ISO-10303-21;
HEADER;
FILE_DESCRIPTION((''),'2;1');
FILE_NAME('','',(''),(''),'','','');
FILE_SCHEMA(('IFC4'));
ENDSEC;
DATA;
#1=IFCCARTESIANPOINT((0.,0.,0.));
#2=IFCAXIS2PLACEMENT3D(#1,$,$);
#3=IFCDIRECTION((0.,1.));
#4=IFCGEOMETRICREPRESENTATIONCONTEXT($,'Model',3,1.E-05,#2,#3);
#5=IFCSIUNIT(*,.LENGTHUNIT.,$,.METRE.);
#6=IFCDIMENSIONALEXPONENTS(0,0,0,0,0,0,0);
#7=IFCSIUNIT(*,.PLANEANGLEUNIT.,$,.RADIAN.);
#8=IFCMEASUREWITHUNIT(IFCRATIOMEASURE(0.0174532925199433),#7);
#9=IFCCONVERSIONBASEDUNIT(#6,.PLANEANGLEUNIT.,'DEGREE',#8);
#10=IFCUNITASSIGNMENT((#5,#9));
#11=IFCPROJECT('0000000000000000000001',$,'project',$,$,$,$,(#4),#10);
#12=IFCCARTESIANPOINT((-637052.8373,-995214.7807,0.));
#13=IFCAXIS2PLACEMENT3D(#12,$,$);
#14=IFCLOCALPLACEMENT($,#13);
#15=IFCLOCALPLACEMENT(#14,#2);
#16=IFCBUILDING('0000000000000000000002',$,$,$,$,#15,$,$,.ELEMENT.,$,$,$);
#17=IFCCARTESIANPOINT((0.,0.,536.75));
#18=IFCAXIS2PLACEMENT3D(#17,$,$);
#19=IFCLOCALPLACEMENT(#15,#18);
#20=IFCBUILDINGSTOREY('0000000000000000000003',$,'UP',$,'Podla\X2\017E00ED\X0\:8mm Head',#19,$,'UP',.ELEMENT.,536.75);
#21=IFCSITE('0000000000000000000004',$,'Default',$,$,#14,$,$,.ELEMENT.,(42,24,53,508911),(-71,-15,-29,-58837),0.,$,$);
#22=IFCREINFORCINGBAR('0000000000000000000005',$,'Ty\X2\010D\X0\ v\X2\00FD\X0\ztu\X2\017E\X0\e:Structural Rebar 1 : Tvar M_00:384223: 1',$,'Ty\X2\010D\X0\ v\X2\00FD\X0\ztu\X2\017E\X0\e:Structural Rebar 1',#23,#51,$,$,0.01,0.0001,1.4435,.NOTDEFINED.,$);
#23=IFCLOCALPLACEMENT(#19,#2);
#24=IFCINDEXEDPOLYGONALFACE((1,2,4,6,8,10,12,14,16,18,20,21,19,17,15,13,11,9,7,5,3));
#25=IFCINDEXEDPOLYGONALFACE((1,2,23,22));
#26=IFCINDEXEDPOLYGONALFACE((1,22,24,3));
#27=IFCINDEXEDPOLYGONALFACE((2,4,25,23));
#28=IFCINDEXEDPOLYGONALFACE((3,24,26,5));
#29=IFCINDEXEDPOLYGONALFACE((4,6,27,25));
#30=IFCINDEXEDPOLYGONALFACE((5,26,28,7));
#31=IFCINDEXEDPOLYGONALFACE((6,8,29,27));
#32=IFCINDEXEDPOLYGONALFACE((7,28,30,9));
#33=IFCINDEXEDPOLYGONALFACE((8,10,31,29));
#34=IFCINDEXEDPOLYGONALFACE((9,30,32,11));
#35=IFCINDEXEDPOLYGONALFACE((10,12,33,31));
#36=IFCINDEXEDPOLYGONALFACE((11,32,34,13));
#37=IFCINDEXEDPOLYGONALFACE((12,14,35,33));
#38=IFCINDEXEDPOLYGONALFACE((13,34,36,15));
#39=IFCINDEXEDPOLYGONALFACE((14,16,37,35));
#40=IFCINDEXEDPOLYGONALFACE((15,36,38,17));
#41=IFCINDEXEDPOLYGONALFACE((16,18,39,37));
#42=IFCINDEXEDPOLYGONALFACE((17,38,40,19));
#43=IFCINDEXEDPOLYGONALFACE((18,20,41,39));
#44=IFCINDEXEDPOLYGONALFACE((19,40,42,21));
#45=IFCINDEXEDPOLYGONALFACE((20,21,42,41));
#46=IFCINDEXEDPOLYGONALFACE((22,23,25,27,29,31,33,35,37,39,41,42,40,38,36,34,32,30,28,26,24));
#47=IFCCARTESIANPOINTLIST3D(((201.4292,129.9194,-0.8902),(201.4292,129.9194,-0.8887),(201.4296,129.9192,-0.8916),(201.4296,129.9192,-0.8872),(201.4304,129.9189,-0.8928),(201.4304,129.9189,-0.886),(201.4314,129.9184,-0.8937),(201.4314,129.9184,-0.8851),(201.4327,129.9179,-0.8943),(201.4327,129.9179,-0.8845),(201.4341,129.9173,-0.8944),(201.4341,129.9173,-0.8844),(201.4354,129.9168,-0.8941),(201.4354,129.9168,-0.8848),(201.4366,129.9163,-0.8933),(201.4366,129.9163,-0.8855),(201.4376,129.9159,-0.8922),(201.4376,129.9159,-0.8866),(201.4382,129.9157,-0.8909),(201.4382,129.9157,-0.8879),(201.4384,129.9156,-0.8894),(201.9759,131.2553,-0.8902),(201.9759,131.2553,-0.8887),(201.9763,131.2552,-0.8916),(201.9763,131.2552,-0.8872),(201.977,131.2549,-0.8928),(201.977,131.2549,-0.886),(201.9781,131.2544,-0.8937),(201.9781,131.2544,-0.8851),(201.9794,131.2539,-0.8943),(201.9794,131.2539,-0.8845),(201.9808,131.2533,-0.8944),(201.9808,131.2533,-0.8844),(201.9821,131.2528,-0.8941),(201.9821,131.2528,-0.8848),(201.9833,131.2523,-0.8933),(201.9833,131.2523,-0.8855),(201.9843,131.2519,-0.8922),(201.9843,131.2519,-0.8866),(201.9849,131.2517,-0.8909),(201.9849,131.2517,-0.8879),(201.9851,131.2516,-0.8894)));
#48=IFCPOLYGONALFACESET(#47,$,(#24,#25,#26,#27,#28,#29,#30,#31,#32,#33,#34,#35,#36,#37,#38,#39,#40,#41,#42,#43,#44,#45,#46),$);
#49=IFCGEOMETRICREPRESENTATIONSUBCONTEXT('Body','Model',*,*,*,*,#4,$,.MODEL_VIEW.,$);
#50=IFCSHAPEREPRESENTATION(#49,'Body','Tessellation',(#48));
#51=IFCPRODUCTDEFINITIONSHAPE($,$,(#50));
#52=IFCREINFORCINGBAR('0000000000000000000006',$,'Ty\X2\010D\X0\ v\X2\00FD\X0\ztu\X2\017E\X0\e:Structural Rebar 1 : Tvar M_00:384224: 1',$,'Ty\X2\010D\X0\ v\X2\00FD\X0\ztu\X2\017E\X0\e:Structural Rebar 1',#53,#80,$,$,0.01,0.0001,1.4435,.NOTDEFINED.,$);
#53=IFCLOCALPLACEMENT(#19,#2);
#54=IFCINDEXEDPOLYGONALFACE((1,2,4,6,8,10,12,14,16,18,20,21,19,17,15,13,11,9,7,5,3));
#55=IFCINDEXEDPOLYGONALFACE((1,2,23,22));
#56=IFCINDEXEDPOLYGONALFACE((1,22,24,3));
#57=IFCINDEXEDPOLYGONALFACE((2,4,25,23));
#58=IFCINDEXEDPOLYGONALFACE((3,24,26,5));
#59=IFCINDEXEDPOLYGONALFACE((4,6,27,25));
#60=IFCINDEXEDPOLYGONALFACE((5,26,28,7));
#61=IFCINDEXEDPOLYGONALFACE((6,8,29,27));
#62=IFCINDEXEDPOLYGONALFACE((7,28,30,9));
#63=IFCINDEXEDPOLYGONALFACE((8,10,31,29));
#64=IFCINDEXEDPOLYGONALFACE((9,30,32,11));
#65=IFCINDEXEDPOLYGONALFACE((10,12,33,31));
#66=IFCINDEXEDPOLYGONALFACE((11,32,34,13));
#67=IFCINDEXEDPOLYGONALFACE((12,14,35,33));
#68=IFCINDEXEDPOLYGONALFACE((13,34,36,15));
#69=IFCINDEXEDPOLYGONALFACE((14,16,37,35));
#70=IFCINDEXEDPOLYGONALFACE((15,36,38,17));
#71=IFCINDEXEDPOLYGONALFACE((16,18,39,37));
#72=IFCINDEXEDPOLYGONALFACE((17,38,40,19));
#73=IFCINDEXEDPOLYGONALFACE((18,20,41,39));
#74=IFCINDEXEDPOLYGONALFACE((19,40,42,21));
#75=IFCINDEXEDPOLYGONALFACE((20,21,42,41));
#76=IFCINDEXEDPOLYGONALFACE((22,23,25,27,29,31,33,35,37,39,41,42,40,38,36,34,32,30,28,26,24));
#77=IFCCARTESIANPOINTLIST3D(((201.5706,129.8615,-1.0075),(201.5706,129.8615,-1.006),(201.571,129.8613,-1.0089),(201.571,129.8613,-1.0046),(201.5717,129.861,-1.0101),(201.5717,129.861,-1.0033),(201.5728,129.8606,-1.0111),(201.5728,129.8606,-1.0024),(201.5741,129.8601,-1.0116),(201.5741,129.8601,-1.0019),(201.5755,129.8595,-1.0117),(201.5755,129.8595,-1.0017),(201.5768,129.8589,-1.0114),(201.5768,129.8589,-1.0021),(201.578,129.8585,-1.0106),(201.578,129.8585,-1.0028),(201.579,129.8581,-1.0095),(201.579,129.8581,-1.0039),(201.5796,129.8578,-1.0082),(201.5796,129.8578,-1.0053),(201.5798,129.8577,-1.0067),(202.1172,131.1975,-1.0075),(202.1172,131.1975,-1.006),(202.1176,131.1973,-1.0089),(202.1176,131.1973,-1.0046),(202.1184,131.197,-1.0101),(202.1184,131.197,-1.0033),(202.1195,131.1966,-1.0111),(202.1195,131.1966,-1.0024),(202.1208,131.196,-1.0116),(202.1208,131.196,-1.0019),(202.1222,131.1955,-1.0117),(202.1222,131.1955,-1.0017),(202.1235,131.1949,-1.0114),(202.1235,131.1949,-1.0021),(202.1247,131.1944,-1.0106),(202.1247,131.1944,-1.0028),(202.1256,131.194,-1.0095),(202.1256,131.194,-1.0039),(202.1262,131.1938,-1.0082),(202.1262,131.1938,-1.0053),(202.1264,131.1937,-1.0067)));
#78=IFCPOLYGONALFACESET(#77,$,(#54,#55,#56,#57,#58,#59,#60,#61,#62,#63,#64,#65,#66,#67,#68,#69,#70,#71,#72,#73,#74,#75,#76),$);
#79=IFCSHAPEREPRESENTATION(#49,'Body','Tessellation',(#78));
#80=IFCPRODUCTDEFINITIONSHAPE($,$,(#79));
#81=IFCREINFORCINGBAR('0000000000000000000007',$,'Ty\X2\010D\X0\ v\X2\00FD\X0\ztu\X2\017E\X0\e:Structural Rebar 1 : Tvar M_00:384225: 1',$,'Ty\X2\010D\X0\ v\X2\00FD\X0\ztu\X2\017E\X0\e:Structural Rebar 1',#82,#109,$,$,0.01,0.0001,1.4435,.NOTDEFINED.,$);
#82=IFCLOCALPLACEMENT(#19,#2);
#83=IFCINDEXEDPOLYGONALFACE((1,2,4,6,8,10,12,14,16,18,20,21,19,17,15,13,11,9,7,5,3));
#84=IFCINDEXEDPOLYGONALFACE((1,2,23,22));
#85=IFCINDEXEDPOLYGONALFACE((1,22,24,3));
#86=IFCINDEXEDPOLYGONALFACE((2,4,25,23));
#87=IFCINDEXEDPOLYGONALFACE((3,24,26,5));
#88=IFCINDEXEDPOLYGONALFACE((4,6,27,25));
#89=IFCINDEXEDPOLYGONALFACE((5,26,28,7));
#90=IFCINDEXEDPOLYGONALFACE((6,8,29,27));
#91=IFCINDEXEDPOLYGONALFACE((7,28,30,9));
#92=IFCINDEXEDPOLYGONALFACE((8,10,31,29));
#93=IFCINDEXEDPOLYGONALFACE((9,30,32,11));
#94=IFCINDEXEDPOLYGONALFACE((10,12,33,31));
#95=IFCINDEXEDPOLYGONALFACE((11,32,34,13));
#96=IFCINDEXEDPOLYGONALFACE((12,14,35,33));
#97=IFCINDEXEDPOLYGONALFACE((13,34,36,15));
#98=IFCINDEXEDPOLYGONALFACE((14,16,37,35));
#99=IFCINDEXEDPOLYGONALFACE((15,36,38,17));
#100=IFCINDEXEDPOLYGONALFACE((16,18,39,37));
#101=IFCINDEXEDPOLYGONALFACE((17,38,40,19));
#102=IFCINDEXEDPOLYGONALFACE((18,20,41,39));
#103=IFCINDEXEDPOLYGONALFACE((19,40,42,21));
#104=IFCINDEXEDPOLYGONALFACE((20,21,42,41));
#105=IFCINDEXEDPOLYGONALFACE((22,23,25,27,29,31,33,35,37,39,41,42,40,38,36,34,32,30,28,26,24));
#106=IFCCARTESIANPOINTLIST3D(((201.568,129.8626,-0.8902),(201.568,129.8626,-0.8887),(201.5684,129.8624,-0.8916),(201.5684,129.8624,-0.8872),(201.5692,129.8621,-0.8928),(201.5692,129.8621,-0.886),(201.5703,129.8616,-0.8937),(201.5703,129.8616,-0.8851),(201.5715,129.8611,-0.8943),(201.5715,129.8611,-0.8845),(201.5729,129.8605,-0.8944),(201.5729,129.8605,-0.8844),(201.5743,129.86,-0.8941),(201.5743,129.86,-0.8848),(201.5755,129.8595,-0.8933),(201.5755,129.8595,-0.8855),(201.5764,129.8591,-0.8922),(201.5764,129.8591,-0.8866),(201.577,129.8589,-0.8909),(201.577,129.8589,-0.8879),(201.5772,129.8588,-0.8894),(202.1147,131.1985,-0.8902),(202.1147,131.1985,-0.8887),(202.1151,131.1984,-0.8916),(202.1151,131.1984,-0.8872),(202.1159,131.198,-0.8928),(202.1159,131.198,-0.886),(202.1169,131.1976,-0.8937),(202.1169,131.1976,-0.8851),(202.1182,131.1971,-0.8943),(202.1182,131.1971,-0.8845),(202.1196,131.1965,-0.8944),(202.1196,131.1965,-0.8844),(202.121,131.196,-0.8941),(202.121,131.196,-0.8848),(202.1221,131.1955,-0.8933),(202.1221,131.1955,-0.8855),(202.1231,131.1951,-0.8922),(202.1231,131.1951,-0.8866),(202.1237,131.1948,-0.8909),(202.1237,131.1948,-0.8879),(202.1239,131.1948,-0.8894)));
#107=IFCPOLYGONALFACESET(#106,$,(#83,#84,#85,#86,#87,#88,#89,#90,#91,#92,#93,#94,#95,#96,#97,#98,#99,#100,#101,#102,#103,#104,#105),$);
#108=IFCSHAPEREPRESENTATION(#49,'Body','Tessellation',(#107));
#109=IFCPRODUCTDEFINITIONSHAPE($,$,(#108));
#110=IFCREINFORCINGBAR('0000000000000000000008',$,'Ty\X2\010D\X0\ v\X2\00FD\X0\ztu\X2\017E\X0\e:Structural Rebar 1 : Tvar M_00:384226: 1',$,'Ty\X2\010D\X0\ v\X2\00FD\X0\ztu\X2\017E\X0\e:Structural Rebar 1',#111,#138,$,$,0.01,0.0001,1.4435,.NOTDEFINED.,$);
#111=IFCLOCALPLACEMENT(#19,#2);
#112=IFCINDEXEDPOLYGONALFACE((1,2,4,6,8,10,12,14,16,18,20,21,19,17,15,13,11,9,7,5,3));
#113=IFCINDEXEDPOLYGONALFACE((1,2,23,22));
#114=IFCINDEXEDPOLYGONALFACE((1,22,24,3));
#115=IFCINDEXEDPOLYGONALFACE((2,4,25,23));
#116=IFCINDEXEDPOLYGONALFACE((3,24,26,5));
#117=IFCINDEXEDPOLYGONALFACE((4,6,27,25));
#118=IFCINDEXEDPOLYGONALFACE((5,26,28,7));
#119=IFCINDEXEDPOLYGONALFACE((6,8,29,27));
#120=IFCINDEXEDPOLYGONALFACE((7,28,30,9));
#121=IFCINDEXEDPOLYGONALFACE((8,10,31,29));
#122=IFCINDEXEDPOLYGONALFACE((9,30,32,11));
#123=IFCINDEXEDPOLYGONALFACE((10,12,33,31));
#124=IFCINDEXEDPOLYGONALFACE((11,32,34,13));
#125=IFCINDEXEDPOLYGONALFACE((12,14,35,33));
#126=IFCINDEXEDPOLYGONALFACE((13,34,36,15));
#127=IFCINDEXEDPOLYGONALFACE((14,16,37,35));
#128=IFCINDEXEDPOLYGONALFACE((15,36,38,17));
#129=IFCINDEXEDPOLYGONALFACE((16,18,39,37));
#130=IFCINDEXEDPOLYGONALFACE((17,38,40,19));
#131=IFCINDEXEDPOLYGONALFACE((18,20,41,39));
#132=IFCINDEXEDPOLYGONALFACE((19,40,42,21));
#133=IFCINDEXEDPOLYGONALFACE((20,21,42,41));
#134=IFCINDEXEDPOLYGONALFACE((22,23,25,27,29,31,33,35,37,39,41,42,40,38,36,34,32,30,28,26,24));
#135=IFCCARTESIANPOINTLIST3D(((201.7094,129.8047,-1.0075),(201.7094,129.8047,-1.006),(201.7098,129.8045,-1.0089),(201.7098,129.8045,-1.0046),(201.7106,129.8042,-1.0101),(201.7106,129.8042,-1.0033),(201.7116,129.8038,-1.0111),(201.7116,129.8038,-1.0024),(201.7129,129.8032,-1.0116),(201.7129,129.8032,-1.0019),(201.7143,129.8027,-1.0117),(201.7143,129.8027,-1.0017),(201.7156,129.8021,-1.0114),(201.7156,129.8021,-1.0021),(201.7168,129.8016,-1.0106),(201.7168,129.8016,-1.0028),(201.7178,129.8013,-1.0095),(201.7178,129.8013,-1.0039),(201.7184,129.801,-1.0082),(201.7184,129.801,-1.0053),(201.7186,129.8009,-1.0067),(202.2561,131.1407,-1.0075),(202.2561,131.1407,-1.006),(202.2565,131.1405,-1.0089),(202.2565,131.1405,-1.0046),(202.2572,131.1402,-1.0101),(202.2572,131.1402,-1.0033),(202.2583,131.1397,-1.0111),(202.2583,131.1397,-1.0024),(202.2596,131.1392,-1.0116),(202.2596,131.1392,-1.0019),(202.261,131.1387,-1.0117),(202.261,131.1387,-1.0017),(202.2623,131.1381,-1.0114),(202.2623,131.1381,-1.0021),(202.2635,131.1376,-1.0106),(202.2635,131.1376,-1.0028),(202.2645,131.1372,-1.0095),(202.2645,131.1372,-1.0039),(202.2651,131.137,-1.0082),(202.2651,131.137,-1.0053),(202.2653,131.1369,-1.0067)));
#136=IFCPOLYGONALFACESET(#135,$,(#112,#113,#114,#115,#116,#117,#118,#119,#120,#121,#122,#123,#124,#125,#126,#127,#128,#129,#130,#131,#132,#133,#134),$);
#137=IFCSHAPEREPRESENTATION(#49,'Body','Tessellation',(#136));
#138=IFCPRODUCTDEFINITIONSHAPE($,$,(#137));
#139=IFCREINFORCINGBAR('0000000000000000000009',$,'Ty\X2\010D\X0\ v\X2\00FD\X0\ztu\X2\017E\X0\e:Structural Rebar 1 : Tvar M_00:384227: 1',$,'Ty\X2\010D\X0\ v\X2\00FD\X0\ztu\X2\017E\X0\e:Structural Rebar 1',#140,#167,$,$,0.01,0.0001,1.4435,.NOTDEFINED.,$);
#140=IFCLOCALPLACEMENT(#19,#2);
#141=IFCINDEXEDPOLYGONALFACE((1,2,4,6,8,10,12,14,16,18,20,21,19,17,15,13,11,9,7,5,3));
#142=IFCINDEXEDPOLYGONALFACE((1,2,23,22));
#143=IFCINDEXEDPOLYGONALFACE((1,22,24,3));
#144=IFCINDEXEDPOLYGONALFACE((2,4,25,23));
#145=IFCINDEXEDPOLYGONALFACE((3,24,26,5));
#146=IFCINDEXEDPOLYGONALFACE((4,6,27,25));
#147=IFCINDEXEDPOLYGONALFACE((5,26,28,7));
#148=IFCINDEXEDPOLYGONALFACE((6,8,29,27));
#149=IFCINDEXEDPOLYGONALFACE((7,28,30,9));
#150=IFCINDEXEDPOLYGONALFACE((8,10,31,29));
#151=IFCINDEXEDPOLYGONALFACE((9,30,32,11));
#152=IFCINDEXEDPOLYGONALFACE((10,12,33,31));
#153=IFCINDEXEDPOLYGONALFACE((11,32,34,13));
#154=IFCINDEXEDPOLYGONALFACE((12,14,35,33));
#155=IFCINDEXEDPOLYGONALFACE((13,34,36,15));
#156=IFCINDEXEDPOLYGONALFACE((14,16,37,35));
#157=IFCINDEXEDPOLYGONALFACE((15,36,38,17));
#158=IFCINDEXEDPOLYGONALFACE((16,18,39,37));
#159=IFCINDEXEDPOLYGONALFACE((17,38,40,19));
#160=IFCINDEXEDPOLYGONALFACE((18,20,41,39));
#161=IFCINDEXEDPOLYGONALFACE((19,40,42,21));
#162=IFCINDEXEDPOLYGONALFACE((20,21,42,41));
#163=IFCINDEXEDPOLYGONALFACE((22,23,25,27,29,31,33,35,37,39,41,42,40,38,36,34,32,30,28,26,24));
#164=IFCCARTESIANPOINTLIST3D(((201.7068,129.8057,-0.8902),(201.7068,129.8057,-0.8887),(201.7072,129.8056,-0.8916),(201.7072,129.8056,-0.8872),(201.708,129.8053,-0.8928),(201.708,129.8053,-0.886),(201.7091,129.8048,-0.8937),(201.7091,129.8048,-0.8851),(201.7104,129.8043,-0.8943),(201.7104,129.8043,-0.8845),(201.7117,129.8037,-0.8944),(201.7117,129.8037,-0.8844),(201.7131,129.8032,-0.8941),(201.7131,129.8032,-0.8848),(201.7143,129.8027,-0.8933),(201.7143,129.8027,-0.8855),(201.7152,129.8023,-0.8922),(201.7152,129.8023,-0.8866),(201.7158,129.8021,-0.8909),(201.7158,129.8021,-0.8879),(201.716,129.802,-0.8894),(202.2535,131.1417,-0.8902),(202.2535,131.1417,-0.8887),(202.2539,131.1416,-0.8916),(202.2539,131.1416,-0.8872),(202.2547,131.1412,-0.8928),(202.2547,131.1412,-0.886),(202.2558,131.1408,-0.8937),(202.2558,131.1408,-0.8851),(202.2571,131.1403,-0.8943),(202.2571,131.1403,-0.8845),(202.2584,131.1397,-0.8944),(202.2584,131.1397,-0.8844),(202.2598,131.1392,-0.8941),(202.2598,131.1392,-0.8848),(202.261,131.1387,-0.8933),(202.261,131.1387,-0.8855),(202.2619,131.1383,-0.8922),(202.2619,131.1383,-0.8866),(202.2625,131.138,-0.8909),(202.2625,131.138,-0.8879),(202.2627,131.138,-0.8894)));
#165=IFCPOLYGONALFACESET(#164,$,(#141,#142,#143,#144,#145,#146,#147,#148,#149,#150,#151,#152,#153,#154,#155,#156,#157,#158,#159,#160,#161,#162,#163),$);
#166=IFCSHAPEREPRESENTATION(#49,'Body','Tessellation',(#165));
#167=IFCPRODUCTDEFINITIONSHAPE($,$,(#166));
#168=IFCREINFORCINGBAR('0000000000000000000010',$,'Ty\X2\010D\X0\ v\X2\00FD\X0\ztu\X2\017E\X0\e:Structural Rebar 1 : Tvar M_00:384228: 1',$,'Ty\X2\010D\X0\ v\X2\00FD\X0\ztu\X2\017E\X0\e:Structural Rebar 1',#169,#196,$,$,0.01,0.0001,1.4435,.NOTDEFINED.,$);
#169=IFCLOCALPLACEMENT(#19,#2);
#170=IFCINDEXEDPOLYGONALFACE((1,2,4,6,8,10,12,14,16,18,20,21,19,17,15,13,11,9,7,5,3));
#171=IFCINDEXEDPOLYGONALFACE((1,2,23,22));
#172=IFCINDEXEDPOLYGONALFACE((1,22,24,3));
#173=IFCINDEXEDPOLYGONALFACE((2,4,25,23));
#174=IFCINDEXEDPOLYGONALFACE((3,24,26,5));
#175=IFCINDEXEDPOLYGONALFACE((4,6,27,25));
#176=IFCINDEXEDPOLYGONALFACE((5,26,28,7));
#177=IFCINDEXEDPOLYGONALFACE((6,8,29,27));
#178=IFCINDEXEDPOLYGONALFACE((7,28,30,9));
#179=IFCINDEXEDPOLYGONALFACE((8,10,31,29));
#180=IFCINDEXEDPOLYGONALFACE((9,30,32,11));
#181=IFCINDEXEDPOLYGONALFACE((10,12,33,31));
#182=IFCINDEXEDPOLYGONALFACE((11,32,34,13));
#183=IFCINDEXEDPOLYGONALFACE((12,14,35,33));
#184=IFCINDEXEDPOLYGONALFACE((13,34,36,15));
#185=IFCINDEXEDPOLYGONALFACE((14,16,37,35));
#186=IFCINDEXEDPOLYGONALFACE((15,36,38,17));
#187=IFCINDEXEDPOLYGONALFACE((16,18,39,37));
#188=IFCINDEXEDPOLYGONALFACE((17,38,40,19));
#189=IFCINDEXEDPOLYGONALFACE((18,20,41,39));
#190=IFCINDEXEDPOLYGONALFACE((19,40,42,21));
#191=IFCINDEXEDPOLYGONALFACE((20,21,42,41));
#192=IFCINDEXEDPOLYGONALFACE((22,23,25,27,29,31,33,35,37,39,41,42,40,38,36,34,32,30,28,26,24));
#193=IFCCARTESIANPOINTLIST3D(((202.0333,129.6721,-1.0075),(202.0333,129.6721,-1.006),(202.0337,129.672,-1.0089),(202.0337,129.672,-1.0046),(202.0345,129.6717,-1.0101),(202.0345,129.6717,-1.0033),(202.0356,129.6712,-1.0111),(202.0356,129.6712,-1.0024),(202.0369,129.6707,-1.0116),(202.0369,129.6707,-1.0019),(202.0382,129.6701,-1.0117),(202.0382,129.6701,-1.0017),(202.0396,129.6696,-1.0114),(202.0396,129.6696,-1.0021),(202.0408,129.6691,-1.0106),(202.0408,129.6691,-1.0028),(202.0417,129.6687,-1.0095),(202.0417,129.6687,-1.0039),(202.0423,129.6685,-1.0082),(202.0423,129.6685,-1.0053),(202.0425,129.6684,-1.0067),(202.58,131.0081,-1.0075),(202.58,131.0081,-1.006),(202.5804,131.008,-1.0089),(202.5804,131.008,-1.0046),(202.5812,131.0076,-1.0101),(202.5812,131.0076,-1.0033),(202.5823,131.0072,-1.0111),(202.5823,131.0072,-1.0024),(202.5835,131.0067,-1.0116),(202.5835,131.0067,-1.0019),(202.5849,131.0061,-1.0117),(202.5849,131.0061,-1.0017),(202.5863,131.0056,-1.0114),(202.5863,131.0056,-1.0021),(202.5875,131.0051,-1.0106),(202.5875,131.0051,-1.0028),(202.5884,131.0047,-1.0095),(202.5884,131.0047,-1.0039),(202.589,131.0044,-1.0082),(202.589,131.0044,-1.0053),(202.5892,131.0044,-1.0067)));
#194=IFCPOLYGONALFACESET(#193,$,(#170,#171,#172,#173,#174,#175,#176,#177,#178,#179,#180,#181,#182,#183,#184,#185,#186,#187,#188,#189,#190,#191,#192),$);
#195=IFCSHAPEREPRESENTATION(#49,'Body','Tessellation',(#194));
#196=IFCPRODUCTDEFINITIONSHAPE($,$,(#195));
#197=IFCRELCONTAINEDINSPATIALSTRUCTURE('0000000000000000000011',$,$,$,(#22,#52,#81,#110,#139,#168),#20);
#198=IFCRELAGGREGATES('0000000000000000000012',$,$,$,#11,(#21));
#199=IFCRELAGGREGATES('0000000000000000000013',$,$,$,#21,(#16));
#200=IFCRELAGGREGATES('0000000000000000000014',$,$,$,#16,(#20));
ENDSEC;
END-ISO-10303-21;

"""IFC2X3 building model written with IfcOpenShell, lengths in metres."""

from ifc_helpers import new_model, entity, si_unit, converted_unit, direction, frame, origin, place, context, subcontext, project, spatial, element, save


model = new_model("IFC2X3")

# Units and contexts
model_context = context("Model", 3, precision=1e-05, world=origin(), true_north=direction((0.0, 1.0)))
body_context = subcontext(model_context, "Body", "Model", "MODEL_VIEW")
ifc_project = project(units=[si_unit("LENGTHUNIT", "METRE"), converted_unit("PLANEANGLEUNIT", "DEGREE", entity("IfcRatioMeasure", 0.0174532925199433), si_unit("PLANEANGLEUNIT", "RADIAN"), dimensions=[0, 0, 0, 0, 0, 0, 0])], contexts=[model_context])

# Site, building, storey
site_placement = place(None, frame((-637052.8373, -995214.7807, 0.0)))
site = spatial("IfcSite", under=ifc_project, at=site_placement, Name="Default", CompositionType="ELEMENT", RefLatitude=(42, 24, 53, 508911), RefLongitude=(-71, -15, -29, -58837), RefElevation=0.0)
building_placement = place(site_placement, origin())
building = spatial("IfcBuilding", under=site, at=building_placement, CompositionType="ELEMENT")
storey_placement = place(building_placement, frame((0.0, 0.0, 536.75)))
storey = spatial("IfcBuildingStorey", under=building, at=storey_placement, Name="UP", ObjectType="Podlaží:8mm Head", LongName="UP", CompositionType="ELEMENT", Elevation=536.75)

# Reinforcing bars
reinforcing_bar_1_placement = place(storey_placement, origin())
element("IfcReinforcingBar", 1, at=reinforcing_bar_1_placement, inside=storey, Name="Tyč výztuže:Structural Rebar 1 : Tvar M_00:384223: 1", ObjectType="Tyč výztuže:Structural Rebar 1", BarLength=1.4435, BarRole="NOTDEFINED", CrossSectionArea=0.0001, NominalDiameter=0.01, context=body_context, shape_type="AdvancedSweptSolid", body=[
    entity("IfcSweptDiskSolid", entity("IfcCompositeCurve", [entity("IfcCompositeCurveSegment", "CONTINUOUS", True, entity("IfcPolyline", [entity("IfcCartesianPoint", [-201.9804, -131.2535, 0.8894]), entity("IfcCartesianPoint", [-201.4337, -129.9175, 0.8894])]))], False), 0.005, None, 0.0, 1.0),
])
reinforcing_bar_2_placement = place(storey_placement, origin())
element("IfcReinforcingBar", 2, at=reinforcing_bar_2_placement, inside=storey, Name="Tyč výztuže:Structural Rebar 1 : Tvar M_00:384224: 1", ObjectType="Tyč výztuže:Structural Rebar 1", BarLength=1.4435, BarRole="NOTDEFINED", CrossSectionArea=0.0001, NominalDiameter=0.01, context=body_context, shape_type="AdvancedSweptSolid", body=[
    entity("IfcSweptDiskSolid", entity("IfcCompositeCurve", [entity("IfcCompositeCurveSegment", "CONTINUOUS", True, entity("IfcPolyline", [entity("IfcCartesianPoint", [-202.1218, -131.1956, 1.0067]), entity("IfcCartesianPoint", [-201.5751, -129.8596, 1.0067])]))], False), 0.005, None, 0.0, 1.0),
])
reinforcing_bar_3_placement = place(storey_placement, origin())
element("IfcReinforcingBar", 3, at=reinforcing_bar_3_placement, inside=storey, Name="Tyč výztuže:Structural Rebar 1 : Tvar M_00:384225: 1", ObjectType="Tyč výztuže:Structural Rebar 1", BarLength=1.4435, BarRole="NOTDEFINED", CrossSectionArea=0.0001, NominalDiameter=0.01, context=body_context, shape_type="AdvancedSweptSolid", body=[
    entity("IfcSweptDiskSolid", entity("IfcCompositeCurve", [entity("IfcCompositeCurveSegment", "CONTINUOUS", True, entity("IfcPolyline", [entity("IfcCartesianPoint", [-202.1193, -131.1967, 0.8894]), entity("IfcCartesianPoint", [-201.5726, -129.8607, 0.8894])]))], False), 0.005, None, 0.0, 1.0),
])
reinforcing_bar_4_placement = place(storey_placement, origin())
element("IfcReinforcingBar", 4, at=reinforcing_bar_4_placement, inside=storey, Name="Tyč výztuže:Structural Rebar 1 : Tvar M_00:384226: 1", ObjectType="Tyč výztuže:Structural Rebar 1", BarLength=1.4435, BarRole="NOTDEFINED", CrossSectionArea=0.0001, NominalDiameter=0.01, context=body_context, shape_type="AdvancedSweptSolid", body=[
    entity("IfcSweptDiskSolid", entity("IfcCompositeCurve", [entity("IfcCompositeCurveSegment", "CONTINUOUS", True, entity("IfcPolyline", [entity("IfcCartesianPoint", [-202.2606, -131.1388, 1.0067]), entity("IfcCartesianPoint", [-201.714, -129.8028, 1.0067])]))], False), 0.005, None, 0.0, 1.0),
])
reinforcing_bar_5_placement = place(storey_placement, origin())
element("IfcReinforcingBar", 5, at=reinforcing_bar_5_placement, inside=storey, Name="Tyč výztuže:Structural Rebar 1 : Tvar M_00:384227: 1", ObjectType="Tyč výztuže:Structural Rebar 1", BarLength=1.4435, BarRole="NOTDEFINED", CrossSectionArea=0.0001, NominalDiameter=0.01, context=body_context, shape_type="AdvancedSweptSolid", body=[
    entity("IfcSweptDiskSolid", entity("IfcCompositeCurve", [entity("IfcCompositeCurveSegment", "CONTINUOUS", True, entity("IfcPolyline", [entity("IfcCartesianPoint", [-202.2581, -131.1398, 0.8894]), entity("IfcCartesianPoint", [-201.7114, -129.8039, 0.8894])]))], False), 0.005, None, 0.0, 1.0),
])
reinforcing_bar_6_placement = place(storey_placement, origin())
element("IfcReinforcingBar", 6, at=reinforcing_bar_6_placement, inside=storey, Name="Tyč výztuže:Structural Rebar 1 : Tvar M_00:384228: 1", ObjectType="Tyč výztuže:Structural Rebar 1", BarLength=1.4435, BarRole="NOTDEFINED", CrossSectionArea=0.0001, NominalDiameter=0.01, context=body_context, shape_type="AdvancedSweptSolid", body=[
    entity("IfcSweptDiskSolid", entity("IfcCompositeCurve", [entity("IfcCompositeCurveSegment", "CONTINUOUS", True, entity("IfcPolyline", [entity("IfcCartesianPoint", [-202.5846, -131.0062, 1.0067]), entity("IfcCartesianPoint", [-202.0379, -129.6703, 1.0067])]))], False), 0.005, None, 0.0, 1.0),
])

save(model, "model.ifc")
